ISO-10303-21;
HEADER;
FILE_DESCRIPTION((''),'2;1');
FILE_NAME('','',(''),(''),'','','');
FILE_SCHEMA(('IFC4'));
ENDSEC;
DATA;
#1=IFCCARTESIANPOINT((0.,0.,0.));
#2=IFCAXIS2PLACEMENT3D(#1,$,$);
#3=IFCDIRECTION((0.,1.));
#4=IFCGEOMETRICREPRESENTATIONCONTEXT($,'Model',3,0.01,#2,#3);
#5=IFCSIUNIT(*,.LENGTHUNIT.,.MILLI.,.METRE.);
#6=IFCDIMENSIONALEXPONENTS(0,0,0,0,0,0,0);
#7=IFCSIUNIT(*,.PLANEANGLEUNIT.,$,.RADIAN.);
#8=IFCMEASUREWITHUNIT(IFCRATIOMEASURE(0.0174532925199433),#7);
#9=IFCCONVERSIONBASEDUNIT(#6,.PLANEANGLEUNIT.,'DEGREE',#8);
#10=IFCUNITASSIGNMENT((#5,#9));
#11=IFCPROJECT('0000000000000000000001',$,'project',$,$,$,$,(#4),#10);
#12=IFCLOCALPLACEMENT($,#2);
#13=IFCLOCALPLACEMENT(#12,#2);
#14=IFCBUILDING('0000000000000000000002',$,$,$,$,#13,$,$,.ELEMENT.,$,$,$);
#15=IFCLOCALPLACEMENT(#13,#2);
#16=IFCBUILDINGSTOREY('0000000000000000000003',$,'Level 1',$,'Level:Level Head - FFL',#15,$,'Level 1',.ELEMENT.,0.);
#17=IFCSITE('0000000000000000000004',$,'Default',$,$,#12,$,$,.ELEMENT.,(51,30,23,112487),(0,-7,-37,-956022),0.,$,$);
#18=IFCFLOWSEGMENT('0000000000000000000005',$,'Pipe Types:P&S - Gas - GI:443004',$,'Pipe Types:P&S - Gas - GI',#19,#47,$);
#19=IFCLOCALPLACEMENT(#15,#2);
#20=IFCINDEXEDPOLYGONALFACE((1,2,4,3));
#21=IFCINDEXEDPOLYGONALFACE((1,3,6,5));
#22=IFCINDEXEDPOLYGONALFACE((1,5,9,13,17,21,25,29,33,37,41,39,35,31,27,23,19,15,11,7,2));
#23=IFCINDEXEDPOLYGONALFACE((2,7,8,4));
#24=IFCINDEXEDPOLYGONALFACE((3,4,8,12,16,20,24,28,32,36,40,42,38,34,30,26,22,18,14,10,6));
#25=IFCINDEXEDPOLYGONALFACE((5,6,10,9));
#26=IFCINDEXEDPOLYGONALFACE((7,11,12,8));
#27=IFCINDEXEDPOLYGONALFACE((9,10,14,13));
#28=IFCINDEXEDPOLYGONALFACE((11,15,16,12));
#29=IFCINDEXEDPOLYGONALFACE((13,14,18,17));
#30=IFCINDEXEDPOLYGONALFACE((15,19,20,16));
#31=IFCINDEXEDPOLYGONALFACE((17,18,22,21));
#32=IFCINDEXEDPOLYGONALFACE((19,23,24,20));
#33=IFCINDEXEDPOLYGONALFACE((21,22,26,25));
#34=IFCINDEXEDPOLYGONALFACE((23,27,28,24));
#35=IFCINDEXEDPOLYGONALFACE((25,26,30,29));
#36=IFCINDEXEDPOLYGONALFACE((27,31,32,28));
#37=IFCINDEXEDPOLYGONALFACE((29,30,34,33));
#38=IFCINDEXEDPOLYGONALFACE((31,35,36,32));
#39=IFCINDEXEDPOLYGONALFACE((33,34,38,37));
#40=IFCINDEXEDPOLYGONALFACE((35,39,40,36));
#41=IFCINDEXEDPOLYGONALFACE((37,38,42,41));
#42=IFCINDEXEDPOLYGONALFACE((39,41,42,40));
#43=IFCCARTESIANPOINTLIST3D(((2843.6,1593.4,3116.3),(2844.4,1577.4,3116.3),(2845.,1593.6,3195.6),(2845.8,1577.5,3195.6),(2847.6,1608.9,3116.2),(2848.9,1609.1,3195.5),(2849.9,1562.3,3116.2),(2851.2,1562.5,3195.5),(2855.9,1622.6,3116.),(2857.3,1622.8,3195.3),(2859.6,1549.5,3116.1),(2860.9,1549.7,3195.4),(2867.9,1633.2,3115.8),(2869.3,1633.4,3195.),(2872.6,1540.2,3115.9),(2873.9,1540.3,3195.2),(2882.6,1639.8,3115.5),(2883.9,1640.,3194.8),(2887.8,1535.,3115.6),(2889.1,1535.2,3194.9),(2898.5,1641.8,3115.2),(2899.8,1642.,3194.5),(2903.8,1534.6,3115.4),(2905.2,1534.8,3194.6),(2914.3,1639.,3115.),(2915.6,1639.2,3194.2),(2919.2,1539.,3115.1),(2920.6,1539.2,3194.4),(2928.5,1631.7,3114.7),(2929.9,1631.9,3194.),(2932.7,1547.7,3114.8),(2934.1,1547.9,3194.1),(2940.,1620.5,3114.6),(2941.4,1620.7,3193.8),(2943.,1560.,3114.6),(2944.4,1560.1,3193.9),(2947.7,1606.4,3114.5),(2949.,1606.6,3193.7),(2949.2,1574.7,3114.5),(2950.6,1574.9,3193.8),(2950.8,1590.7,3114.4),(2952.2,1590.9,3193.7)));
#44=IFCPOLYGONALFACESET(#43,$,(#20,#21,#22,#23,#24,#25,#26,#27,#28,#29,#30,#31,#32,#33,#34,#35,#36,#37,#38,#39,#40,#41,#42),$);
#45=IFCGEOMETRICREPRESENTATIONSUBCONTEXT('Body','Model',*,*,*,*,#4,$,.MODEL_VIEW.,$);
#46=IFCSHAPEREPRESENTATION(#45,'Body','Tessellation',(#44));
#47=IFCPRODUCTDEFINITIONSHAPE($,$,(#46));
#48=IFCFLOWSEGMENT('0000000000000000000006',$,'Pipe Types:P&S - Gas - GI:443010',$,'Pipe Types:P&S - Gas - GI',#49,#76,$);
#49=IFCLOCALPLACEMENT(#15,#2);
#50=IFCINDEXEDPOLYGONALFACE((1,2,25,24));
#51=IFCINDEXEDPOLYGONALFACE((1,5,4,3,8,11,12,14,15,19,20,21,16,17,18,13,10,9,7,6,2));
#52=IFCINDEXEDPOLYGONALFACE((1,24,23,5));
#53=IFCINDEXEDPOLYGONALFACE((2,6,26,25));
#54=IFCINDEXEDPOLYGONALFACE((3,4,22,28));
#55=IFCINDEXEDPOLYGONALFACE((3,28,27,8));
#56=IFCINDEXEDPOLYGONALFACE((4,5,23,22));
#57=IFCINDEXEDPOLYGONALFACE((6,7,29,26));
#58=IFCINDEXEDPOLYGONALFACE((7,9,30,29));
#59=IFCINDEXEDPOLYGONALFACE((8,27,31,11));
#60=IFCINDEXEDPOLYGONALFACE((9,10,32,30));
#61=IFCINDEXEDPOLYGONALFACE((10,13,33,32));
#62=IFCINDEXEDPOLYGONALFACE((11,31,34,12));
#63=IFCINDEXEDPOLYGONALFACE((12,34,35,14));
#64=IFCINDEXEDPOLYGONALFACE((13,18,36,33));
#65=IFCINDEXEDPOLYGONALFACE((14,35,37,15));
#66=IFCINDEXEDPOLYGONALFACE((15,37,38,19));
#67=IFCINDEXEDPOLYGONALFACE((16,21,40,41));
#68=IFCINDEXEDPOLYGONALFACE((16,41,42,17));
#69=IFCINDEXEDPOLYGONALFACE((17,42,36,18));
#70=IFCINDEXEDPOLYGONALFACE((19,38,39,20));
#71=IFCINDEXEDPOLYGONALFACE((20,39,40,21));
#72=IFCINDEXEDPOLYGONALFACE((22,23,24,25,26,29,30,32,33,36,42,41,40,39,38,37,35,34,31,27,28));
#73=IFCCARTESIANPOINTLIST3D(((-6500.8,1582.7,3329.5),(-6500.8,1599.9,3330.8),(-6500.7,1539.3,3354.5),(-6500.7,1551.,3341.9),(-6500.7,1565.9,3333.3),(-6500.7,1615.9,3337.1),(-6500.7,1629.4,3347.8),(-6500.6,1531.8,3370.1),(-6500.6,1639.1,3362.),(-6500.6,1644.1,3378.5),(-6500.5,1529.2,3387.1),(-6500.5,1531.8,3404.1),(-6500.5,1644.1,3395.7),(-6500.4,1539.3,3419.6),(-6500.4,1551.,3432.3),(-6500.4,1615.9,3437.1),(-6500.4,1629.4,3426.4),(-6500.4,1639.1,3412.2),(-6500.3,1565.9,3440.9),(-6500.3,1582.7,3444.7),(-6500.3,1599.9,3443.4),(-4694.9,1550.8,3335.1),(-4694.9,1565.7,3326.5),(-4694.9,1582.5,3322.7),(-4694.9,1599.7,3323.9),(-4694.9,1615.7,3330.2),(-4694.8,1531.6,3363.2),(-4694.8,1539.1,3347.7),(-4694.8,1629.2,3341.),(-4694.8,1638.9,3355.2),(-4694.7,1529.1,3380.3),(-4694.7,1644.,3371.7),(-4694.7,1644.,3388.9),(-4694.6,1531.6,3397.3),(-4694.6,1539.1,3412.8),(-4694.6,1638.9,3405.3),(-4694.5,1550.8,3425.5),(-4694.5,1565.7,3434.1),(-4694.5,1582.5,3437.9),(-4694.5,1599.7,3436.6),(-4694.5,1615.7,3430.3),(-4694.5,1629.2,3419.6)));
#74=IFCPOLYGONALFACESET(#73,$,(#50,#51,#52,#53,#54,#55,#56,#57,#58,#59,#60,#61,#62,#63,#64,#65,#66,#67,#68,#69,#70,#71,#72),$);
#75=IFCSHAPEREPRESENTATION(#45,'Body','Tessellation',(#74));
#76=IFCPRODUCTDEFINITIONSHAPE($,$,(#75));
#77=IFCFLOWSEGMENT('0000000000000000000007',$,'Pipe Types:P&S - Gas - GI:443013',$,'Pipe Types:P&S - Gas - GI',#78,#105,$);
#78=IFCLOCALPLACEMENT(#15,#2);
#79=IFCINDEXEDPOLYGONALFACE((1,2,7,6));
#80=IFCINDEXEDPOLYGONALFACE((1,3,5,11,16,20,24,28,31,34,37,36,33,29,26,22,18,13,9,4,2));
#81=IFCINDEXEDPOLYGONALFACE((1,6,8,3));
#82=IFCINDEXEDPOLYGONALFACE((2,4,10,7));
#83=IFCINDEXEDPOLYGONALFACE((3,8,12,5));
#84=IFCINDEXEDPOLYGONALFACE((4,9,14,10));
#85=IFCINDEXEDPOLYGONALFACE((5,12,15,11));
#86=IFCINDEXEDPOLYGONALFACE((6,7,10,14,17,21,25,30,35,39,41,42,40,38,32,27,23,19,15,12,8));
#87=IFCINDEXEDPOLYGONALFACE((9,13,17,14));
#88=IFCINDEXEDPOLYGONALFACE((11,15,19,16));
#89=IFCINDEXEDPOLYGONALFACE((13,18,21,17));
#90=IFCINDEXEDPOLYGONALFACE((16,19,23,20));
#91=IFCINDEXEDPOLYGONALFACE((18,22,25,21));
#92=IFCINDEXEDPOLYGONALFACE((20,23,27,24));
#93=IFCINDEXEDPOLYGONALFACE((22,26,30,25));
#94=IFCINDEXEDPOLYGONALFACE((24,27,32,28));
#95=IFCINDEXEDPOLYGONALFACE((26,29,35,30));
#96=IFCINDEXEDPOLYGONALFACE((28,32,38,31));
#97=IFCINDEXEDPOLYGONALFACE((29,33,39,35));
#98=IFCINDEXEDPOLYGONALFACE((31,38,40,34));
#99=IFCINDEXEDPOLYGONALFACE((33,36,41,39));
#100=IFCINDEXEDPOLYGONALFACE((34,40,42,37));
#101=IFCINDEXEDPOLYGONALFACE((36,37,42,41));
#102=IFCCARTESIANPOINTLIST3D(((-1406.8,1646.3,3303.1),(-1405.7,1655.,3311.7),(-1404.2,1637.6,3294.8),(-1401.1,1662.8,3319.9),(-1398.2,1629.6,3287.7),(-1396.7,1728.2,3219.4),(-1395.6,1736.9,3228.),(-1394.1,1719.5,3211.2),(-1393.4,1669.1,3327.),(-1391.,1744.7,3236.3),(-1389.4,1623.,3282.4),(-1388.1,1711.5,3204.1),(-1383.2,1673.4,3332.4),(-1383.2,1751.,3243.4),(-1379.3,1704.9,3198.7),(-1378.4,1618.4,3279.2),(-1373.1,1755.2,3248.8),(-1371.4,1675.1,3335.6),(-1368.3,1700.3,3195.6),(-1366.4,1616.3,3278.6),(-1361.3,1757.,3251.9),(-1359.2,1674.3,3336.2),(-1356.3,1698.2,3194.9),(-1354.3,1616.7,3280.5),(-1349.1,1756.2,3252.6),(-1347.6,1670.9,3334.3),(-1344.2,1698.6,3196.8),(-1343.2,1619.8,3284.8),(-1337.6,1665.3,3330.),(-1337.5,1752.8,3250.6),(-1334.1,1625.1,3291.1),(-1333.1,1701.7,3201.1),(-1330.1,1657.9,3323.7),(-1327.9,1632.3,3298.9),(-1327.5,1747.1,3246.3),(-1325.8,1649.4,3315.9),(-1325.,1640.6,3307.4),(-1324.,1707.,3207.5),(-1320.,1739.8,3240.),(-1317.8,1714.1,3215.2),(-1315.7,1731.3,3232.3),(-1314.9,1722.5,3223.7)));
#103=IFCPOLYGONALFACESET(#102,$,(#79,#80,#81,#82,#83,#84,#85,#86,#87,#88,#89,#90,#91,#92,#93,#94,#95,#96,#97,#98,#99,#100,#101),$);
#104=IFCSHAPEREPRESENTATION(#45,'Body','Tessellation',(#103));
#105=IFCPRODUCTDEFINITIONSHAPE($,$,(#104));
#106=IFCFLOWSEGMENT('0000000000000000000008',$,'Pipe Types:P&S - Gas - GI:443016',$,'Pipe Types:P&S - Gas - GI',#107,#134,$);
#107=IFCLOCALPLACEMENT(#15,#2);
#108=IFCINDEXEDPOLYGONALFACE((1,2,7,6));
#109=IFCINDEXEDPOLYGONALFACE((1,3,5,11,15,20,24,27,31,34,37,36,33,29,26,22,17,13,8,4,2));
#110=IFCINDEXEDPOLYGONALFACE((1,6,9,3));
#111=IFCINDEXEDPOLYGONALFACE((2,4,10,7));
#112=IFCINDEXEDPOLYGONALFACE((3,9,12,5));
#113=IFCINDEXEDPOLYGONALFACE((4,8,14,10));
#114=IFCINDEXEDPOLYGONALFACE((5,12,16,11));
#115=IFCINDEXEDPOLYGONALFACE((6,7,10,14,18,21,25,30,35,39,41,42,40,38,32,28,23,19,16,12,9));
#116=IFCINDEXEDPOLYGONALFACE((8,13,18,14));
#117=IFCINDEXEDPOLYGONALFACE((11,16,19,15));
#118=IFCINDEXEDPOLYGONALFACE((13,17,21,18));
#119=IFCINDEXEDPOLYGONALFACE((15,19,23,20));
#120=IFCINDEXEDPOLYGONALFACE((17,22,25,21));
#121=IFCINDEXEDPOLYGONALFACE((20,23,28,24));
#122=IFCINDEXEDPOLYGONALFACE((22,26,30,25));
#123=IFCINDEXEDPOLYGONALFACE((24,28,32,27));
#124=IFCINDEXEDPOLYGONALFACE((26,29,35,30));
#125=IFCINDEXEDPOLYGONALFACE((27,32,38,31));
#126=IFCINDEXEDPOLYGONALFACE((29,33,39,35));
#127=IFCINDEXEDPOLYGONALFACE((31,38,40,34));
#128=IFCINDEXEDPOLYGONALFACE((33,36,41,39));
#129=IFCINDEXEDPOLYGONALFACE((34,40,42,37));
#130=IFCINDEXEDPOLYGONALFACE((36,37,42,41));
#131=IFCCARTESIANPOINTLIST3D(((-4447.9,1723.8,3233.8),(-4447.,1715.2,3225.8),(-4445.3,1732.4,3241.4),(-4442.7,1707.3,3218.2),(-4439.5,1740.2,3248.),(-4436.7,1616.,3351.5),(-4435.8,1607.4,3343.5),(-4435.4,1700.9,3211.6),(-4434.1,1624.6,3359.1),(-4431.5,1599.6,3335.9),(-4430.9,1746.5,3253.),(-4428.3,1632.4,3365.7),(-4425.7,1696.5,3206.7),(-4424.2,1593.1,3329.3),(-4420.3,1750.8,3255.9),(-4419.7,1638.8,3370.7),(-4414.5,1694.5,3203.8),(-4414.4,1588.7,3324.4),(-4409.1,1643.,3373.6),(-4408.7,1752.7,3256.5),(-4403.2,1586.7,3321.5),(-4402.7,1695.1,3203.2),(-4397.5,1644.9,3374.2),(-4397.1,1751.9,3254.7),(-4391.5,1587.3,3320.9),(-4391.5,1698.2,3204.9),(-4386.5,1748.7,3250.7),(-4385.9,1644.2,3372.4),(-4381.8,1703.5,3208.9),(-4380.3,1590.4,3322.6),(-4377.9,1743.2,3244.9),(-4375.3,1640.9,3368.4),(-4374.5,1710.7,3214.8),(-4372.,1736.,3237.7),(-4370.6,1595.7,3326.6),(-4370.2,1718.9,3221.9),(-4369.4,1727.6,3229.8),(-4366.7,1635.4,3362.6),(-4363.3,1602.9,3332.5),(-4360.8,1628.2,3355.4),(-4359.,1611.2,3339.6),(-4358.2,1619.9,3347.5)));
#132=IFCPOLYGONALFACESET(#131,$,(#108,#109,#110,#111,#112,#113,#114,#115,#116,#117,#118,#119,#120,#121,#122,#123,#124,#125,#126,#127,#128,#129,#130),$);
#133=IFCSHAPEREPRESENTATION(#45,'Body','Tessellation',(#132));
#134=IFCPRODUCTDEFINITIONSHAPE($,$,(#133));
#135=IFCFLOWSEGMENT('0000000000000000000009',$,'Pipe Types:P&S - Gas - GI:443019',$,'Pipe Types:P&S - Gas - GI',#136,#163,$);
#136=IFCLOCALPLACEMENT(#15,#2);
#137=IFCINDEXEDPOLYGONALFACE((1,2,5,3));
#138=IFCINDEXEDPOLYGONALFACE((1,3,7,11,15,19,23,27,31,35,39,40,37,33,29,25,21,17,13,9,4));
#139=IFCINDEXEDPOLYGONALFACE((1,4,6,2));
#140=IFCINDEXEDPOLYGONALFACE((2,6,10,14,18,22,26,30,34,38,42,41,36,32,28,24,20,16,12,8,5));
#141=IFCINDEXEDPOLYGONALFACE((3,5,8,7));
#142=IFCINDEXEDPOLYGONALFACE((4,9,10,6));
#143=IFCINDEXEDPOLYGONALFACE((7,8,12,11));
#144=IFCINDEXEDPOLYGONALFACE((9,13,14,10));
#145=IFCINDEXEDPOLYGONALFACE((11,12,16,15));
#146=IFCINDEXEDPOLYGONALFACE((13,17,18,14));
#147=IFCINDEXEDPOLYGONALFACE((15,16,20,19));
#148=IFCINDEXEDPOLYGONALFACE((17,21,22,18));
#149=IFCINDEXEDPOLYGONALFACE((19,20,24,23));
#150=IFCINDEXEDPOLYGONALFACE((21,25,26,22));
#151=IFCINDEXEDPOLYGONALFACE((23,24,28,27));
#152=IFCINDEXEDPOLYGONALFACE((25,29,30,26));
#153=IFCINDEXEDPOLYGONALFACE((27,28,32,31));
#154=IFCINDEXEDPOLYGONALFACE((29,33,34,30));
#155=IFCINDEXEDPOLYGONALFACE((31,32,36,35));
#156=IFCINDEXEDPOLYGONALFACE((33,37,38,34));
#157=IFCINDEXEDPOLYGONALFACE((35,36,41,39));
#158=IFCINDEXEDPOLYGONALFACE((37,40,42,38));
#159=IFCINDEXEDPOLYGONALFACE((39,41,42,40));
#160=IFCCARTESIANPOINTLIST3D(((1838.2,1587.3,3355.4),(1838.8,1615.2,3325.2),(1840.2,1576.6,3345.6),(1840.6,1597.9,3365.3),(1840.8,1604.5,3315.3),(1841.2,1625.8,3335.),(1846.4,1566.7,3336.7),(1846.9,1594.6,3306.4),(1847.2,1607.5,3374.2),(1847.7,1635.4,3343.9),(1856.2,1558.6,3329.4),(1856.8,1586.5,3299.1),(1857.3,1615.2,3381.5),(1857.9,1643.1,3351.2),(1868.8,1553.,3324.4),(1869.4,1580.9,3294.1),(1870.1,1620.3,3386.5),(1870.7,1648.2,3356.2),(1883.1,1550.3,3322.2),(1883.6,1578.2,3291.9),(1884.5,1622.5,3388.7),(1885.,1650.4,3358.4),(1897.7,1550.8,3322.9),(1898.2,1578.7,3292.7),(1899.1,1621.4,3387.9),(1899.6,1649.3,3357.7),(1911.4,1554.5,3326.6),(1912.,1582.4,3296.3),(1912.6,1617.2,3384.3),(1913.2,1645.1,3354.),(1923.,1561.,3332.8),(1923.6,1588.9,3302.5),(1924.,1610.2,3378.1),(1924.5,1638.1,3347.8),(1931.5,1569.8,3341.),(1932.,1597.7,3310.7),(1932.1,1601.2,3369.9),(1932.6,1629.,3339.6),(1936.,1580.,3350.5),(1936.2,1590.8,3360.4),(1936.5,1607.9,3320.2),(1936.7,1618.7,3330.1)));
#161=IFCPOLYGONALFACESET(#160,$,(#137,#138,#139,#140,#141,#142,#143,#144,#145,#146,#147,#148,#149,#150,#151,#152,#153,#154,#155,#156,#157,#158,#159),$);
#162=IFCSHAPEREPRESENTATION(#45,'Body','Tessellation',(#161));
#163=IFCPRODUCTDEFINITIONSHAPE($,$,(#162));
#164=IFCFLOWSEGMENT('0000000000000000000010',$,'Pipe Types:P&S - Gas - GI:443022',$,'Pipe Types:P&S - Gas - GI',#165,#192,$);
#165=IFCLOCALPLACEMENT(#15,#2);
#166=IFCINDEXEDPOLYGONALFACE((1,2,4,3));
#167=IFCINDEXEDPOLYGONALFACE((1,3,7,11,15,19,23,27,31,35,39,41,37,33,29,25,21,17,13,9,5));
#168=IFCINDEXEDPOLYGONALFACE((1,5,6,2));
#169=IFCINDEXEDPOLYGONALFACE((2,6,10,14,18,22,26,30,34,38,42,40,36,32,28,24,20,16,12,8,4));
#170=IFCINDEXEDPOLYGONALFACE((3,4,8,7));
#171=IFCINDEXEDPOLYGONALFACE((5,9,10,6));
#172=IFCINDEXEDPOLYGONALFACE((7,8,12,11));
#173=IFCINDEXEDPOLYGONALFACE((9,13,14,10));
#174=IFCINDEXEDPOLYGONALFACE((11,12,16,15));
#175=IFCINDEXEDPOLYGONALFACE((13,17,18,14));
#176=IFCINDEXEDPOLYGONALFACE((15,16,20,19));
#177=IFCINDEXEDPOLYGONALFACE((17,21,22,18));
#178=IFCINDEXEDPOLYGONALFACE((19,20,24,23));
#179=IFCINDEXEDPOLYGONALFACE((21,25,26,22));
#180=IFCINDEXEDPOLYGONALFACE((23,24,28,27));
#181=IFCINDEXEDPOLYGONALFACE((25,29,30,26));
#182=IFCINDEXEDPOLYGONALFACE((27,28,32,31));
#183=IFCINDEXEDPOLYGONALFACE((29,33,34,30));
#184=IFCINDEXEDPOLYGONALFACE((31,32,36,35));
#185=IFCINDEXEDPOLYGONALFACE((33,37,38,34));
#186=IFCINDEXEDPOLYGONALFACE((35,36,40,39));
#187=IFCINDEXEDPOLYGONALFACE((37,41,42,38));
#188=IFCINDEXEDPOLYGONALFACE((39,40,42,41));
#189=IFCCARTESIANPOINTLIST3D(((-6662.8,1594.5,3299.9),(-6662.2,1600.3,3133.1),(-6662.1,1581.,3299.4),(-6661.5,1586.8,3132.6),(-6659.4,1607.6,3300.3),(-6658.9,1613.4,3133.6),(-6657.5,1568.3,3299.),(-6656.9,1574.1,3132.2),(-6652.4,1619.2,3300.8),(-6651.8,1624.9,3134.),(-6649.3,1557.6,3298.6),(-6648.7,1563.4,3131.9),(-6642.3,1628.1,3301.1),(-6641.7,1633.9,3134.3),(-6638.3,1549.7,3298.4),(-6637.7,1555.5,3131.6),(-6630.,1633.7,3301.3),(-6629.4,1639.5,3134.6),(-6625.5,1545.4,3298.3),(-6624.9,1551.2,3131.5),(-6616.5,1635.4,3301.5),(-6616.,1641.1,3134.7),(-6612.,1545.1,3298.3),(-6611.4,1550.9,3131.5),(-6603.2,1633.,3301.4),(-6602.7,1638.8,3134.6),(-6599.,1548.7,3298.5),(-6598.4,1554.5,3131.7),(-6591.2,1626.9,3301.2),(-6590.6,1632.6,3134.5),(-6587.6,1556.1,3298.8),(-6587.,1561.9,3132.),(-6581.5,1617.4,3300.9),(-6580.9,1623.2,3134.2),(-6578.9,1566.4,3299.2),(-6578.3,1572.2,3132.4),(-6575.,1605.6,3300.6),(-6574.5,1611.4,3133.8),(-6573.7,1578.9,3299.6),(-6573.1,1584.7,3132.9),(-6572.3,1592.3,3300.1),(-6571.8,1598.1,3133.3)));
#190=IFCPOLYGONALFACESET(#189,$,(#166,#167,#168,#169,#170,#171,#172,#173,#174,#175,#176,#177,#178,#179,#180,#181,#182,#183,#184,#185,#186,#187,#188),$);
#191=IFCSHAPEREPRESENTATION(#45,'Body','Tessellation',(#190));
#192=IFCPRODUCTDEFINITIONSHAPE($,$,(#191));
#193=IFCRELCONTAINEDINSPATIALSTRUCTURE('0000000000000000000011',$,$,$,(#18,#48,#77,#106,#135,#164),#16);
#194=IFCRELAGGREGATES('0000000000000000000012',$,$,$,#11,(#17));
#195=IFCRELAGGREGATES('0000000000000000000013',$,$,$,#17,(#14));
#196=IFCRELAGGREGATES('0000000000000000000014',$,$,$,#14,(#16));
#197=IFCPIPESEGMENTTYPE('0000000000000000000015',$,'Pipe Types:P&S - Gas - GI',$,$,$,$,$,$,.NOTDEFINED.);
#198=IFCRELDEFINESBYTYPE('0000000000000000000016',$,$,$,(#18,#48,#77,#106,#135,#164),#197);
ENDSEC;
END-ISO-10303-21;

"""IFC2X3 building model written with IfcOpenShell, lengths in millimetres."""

from ifc_helpers import new_model, entity, si_unit, converted_unit, direction, frame, frame_2d, origin, origin_2d_with_axis, place, context, subcontext, project, spatial, circle, extrude, type_object, element, save


model = new_model("IFC2X3")

# Units and contexts
model_context = context("Model", 3, precision=0.01, world=origin(), true_north=direction((0.0, 1.0)))
body_context = subcontext(model_context, "Body", "Model", "MODEL_VIEW")
ifc_project = project(units=[si_unit("LENGTHUNIT", "METRE", prefix="MILLI"), converted_unit("PLANEANGLEUNIT", "DEGREE", entity("IfcRatioMeasure", 0.0174532925199433), si_unit("PLANEANGLEUNIT", "RADIAN"), dimensions=[0, 0, 0, 0, 0, 0, 0])], contexts=[model_context])

# Site, building, storey
site_placement = place(None, origin())
site = spatial("IfcSite", under=ifc_project, at=site_placement, Name="Default", CompositionType="ELEMENT", RefLatitude=(51, 30, 23, 112487), RefLongitude=(0, -7, -37, -956022), RefElevation=0.0)
building_placement = place(site_placement, origin())
building = spatial("IfcBuilding", under=site, at=building_placement, CompositionType="ELEMENT")
storey_placement = place(building_placement, origin())
storey = spatial("IfcBuildingStorey", under=building, at=storey_placement, Name="Level 1", ObjectType="Level:Level Head - FFL", LongName="Level 1", CompositionType="ELEMENT", Elevation=0.0)

# Flow segments
pipe_segment_type = type_object("IfcPipeSegmentType", Name="Pipe Types:P&S - Gas - GI", PredefinedType="NOTDEFINED")
flow_segment_1_placement = place(storey_placement, origin())
element("IfcFlowSegment", 1, at=flow_segment_1_placement, inside=storey, type_object=pipe_segment_type, Name="Pipe Types:P&S - Gas - GI:443004", ObjectType="Pipe Types:P&S - Gas - GI", context=body_context, shape_type="SweptSolid", body=[
    extrude(circle(Radius=53.8, at=origin_2d_with_axis()), frame((2897.1, 1588.0, 3115.4), z_axis=(0.017142, 0.002147, 0.999851), x_axis=(0.124291, -0.992246, 0.0)), (0.0, 0.0, 1.0), 79.3),
])
flow_segment_2_placement = place(storey_placement, origin())
element("IfcFlowSegment", 2, at=flow_segment_2_placement, inside=storey, type_object=pipe_segment_type, Name="Pipe Types:P&S - Gas - GI:443010", ObjectType="Pipe Types:P&S - Gas - GI", context=body_context, shape_type="SweptSolid", body=[
    extrude(circle(Radius=57.8, at=origin_2d_with_axis()), frame((-6500.5, 1587.0, 3387.1), z_axis=(0.999993, -0.000082, -0.003774), x_axis=(-0.000082, -1.0, 0.0)), (0.0, 0.0, 1.0), 1805.9),
])
flow_segment_3_placement = place(storey_placement, origin())
element("IfcFlowSegment", 3, at=flow_segment_3_placement, inside=storey, type_object=pipe_segment_type, Name="Pipe Types:P&S - Gas - GI:443013", ObjectType="Pipe Types:P&S - Gas - GI", context=body_context, shape_type="SweptSolid", body=[
    extrude(circle(Radius=41.2, at=origin_2d_with_axis()), frame((-1355.7, 1727.5, 3223.7), z_axis=(-0.086051, -0.69689, 0.711996), x_axis=(0.992463, -0.122548, 0.0)), (0.0, 0.0, 1.0), 117.5),
])
flow_segment_4_placement = place(storey_placement, origin())
element("IfcFlowSegment", 4, at=flow_segment_4_placement, inside=storey, type_object=pipe_segment_type, Name="Pipe Types:P&S - Gas - GI:443016", ObjectType="Pipe Types:P&S - Gas - GI", context=body_context, shape_type="SweptSolid", body=[
    extrude(circle(Radius=39.5, at=frame_2d((0.0, 0.0), x_axis=(1.0, 0.0))), frame((-4408.7, 1723.6, 3229.8), z_axis=(0.07019, -0.67366, 0.735701), x_axis=(0.994616, 0.103632, 0.0)), (0.0, 0.0, 1.0), 160.0),
])
flow_segment_5_placement = place(storey_placement, origin())
element("IfcFlowSegment", 5, at=flow_segment_5_placement, inside=storey, type_object=pipe_segment_type, Name="Pipe Types:P&S - Gas - GI:443019", ObjectType="Pipe Types:P&S - Gas - GI", context=body_context, shape_type="SweptSolid", body=[
    extrude(circle(Radius=49.2, at=origin_2d_with_axis()), frame((1887.4, 1586.3, 3355.4), z_axis=(0.013144, 0.677583, -0.735329), x_axis=(-0.999812, 0.019394, 0.0)), (0.0, 0.0, 1.0), 41.2),
])
flow_segment_6_placement = place(storey_placement, origin())
element("IfcFlowSegment", 6, at=flow_segment_6_placement, inside=storey, type_object=pipe_segment_type, Name="Pipe Types:P&S - Gas - GI:443022", ObjectType="Pipe Types:P&S - Gas - GI", context=body_context, shape_type="SweptSolid", body=[
    extrude(circle(Radius=45.4, at=frame_2d((0.0, 0.0), x_axis=(1.0, 0.0))), frame((-6617.6, 1590.0, 3299.9), z_axis=(0.00344, 0.034638, -0.999394), x_axis=(-0.995104, 0.098834, 0.0)), (0.0, 0.0, 1.0), 166.9),
])

save(model, "model.ifc")
